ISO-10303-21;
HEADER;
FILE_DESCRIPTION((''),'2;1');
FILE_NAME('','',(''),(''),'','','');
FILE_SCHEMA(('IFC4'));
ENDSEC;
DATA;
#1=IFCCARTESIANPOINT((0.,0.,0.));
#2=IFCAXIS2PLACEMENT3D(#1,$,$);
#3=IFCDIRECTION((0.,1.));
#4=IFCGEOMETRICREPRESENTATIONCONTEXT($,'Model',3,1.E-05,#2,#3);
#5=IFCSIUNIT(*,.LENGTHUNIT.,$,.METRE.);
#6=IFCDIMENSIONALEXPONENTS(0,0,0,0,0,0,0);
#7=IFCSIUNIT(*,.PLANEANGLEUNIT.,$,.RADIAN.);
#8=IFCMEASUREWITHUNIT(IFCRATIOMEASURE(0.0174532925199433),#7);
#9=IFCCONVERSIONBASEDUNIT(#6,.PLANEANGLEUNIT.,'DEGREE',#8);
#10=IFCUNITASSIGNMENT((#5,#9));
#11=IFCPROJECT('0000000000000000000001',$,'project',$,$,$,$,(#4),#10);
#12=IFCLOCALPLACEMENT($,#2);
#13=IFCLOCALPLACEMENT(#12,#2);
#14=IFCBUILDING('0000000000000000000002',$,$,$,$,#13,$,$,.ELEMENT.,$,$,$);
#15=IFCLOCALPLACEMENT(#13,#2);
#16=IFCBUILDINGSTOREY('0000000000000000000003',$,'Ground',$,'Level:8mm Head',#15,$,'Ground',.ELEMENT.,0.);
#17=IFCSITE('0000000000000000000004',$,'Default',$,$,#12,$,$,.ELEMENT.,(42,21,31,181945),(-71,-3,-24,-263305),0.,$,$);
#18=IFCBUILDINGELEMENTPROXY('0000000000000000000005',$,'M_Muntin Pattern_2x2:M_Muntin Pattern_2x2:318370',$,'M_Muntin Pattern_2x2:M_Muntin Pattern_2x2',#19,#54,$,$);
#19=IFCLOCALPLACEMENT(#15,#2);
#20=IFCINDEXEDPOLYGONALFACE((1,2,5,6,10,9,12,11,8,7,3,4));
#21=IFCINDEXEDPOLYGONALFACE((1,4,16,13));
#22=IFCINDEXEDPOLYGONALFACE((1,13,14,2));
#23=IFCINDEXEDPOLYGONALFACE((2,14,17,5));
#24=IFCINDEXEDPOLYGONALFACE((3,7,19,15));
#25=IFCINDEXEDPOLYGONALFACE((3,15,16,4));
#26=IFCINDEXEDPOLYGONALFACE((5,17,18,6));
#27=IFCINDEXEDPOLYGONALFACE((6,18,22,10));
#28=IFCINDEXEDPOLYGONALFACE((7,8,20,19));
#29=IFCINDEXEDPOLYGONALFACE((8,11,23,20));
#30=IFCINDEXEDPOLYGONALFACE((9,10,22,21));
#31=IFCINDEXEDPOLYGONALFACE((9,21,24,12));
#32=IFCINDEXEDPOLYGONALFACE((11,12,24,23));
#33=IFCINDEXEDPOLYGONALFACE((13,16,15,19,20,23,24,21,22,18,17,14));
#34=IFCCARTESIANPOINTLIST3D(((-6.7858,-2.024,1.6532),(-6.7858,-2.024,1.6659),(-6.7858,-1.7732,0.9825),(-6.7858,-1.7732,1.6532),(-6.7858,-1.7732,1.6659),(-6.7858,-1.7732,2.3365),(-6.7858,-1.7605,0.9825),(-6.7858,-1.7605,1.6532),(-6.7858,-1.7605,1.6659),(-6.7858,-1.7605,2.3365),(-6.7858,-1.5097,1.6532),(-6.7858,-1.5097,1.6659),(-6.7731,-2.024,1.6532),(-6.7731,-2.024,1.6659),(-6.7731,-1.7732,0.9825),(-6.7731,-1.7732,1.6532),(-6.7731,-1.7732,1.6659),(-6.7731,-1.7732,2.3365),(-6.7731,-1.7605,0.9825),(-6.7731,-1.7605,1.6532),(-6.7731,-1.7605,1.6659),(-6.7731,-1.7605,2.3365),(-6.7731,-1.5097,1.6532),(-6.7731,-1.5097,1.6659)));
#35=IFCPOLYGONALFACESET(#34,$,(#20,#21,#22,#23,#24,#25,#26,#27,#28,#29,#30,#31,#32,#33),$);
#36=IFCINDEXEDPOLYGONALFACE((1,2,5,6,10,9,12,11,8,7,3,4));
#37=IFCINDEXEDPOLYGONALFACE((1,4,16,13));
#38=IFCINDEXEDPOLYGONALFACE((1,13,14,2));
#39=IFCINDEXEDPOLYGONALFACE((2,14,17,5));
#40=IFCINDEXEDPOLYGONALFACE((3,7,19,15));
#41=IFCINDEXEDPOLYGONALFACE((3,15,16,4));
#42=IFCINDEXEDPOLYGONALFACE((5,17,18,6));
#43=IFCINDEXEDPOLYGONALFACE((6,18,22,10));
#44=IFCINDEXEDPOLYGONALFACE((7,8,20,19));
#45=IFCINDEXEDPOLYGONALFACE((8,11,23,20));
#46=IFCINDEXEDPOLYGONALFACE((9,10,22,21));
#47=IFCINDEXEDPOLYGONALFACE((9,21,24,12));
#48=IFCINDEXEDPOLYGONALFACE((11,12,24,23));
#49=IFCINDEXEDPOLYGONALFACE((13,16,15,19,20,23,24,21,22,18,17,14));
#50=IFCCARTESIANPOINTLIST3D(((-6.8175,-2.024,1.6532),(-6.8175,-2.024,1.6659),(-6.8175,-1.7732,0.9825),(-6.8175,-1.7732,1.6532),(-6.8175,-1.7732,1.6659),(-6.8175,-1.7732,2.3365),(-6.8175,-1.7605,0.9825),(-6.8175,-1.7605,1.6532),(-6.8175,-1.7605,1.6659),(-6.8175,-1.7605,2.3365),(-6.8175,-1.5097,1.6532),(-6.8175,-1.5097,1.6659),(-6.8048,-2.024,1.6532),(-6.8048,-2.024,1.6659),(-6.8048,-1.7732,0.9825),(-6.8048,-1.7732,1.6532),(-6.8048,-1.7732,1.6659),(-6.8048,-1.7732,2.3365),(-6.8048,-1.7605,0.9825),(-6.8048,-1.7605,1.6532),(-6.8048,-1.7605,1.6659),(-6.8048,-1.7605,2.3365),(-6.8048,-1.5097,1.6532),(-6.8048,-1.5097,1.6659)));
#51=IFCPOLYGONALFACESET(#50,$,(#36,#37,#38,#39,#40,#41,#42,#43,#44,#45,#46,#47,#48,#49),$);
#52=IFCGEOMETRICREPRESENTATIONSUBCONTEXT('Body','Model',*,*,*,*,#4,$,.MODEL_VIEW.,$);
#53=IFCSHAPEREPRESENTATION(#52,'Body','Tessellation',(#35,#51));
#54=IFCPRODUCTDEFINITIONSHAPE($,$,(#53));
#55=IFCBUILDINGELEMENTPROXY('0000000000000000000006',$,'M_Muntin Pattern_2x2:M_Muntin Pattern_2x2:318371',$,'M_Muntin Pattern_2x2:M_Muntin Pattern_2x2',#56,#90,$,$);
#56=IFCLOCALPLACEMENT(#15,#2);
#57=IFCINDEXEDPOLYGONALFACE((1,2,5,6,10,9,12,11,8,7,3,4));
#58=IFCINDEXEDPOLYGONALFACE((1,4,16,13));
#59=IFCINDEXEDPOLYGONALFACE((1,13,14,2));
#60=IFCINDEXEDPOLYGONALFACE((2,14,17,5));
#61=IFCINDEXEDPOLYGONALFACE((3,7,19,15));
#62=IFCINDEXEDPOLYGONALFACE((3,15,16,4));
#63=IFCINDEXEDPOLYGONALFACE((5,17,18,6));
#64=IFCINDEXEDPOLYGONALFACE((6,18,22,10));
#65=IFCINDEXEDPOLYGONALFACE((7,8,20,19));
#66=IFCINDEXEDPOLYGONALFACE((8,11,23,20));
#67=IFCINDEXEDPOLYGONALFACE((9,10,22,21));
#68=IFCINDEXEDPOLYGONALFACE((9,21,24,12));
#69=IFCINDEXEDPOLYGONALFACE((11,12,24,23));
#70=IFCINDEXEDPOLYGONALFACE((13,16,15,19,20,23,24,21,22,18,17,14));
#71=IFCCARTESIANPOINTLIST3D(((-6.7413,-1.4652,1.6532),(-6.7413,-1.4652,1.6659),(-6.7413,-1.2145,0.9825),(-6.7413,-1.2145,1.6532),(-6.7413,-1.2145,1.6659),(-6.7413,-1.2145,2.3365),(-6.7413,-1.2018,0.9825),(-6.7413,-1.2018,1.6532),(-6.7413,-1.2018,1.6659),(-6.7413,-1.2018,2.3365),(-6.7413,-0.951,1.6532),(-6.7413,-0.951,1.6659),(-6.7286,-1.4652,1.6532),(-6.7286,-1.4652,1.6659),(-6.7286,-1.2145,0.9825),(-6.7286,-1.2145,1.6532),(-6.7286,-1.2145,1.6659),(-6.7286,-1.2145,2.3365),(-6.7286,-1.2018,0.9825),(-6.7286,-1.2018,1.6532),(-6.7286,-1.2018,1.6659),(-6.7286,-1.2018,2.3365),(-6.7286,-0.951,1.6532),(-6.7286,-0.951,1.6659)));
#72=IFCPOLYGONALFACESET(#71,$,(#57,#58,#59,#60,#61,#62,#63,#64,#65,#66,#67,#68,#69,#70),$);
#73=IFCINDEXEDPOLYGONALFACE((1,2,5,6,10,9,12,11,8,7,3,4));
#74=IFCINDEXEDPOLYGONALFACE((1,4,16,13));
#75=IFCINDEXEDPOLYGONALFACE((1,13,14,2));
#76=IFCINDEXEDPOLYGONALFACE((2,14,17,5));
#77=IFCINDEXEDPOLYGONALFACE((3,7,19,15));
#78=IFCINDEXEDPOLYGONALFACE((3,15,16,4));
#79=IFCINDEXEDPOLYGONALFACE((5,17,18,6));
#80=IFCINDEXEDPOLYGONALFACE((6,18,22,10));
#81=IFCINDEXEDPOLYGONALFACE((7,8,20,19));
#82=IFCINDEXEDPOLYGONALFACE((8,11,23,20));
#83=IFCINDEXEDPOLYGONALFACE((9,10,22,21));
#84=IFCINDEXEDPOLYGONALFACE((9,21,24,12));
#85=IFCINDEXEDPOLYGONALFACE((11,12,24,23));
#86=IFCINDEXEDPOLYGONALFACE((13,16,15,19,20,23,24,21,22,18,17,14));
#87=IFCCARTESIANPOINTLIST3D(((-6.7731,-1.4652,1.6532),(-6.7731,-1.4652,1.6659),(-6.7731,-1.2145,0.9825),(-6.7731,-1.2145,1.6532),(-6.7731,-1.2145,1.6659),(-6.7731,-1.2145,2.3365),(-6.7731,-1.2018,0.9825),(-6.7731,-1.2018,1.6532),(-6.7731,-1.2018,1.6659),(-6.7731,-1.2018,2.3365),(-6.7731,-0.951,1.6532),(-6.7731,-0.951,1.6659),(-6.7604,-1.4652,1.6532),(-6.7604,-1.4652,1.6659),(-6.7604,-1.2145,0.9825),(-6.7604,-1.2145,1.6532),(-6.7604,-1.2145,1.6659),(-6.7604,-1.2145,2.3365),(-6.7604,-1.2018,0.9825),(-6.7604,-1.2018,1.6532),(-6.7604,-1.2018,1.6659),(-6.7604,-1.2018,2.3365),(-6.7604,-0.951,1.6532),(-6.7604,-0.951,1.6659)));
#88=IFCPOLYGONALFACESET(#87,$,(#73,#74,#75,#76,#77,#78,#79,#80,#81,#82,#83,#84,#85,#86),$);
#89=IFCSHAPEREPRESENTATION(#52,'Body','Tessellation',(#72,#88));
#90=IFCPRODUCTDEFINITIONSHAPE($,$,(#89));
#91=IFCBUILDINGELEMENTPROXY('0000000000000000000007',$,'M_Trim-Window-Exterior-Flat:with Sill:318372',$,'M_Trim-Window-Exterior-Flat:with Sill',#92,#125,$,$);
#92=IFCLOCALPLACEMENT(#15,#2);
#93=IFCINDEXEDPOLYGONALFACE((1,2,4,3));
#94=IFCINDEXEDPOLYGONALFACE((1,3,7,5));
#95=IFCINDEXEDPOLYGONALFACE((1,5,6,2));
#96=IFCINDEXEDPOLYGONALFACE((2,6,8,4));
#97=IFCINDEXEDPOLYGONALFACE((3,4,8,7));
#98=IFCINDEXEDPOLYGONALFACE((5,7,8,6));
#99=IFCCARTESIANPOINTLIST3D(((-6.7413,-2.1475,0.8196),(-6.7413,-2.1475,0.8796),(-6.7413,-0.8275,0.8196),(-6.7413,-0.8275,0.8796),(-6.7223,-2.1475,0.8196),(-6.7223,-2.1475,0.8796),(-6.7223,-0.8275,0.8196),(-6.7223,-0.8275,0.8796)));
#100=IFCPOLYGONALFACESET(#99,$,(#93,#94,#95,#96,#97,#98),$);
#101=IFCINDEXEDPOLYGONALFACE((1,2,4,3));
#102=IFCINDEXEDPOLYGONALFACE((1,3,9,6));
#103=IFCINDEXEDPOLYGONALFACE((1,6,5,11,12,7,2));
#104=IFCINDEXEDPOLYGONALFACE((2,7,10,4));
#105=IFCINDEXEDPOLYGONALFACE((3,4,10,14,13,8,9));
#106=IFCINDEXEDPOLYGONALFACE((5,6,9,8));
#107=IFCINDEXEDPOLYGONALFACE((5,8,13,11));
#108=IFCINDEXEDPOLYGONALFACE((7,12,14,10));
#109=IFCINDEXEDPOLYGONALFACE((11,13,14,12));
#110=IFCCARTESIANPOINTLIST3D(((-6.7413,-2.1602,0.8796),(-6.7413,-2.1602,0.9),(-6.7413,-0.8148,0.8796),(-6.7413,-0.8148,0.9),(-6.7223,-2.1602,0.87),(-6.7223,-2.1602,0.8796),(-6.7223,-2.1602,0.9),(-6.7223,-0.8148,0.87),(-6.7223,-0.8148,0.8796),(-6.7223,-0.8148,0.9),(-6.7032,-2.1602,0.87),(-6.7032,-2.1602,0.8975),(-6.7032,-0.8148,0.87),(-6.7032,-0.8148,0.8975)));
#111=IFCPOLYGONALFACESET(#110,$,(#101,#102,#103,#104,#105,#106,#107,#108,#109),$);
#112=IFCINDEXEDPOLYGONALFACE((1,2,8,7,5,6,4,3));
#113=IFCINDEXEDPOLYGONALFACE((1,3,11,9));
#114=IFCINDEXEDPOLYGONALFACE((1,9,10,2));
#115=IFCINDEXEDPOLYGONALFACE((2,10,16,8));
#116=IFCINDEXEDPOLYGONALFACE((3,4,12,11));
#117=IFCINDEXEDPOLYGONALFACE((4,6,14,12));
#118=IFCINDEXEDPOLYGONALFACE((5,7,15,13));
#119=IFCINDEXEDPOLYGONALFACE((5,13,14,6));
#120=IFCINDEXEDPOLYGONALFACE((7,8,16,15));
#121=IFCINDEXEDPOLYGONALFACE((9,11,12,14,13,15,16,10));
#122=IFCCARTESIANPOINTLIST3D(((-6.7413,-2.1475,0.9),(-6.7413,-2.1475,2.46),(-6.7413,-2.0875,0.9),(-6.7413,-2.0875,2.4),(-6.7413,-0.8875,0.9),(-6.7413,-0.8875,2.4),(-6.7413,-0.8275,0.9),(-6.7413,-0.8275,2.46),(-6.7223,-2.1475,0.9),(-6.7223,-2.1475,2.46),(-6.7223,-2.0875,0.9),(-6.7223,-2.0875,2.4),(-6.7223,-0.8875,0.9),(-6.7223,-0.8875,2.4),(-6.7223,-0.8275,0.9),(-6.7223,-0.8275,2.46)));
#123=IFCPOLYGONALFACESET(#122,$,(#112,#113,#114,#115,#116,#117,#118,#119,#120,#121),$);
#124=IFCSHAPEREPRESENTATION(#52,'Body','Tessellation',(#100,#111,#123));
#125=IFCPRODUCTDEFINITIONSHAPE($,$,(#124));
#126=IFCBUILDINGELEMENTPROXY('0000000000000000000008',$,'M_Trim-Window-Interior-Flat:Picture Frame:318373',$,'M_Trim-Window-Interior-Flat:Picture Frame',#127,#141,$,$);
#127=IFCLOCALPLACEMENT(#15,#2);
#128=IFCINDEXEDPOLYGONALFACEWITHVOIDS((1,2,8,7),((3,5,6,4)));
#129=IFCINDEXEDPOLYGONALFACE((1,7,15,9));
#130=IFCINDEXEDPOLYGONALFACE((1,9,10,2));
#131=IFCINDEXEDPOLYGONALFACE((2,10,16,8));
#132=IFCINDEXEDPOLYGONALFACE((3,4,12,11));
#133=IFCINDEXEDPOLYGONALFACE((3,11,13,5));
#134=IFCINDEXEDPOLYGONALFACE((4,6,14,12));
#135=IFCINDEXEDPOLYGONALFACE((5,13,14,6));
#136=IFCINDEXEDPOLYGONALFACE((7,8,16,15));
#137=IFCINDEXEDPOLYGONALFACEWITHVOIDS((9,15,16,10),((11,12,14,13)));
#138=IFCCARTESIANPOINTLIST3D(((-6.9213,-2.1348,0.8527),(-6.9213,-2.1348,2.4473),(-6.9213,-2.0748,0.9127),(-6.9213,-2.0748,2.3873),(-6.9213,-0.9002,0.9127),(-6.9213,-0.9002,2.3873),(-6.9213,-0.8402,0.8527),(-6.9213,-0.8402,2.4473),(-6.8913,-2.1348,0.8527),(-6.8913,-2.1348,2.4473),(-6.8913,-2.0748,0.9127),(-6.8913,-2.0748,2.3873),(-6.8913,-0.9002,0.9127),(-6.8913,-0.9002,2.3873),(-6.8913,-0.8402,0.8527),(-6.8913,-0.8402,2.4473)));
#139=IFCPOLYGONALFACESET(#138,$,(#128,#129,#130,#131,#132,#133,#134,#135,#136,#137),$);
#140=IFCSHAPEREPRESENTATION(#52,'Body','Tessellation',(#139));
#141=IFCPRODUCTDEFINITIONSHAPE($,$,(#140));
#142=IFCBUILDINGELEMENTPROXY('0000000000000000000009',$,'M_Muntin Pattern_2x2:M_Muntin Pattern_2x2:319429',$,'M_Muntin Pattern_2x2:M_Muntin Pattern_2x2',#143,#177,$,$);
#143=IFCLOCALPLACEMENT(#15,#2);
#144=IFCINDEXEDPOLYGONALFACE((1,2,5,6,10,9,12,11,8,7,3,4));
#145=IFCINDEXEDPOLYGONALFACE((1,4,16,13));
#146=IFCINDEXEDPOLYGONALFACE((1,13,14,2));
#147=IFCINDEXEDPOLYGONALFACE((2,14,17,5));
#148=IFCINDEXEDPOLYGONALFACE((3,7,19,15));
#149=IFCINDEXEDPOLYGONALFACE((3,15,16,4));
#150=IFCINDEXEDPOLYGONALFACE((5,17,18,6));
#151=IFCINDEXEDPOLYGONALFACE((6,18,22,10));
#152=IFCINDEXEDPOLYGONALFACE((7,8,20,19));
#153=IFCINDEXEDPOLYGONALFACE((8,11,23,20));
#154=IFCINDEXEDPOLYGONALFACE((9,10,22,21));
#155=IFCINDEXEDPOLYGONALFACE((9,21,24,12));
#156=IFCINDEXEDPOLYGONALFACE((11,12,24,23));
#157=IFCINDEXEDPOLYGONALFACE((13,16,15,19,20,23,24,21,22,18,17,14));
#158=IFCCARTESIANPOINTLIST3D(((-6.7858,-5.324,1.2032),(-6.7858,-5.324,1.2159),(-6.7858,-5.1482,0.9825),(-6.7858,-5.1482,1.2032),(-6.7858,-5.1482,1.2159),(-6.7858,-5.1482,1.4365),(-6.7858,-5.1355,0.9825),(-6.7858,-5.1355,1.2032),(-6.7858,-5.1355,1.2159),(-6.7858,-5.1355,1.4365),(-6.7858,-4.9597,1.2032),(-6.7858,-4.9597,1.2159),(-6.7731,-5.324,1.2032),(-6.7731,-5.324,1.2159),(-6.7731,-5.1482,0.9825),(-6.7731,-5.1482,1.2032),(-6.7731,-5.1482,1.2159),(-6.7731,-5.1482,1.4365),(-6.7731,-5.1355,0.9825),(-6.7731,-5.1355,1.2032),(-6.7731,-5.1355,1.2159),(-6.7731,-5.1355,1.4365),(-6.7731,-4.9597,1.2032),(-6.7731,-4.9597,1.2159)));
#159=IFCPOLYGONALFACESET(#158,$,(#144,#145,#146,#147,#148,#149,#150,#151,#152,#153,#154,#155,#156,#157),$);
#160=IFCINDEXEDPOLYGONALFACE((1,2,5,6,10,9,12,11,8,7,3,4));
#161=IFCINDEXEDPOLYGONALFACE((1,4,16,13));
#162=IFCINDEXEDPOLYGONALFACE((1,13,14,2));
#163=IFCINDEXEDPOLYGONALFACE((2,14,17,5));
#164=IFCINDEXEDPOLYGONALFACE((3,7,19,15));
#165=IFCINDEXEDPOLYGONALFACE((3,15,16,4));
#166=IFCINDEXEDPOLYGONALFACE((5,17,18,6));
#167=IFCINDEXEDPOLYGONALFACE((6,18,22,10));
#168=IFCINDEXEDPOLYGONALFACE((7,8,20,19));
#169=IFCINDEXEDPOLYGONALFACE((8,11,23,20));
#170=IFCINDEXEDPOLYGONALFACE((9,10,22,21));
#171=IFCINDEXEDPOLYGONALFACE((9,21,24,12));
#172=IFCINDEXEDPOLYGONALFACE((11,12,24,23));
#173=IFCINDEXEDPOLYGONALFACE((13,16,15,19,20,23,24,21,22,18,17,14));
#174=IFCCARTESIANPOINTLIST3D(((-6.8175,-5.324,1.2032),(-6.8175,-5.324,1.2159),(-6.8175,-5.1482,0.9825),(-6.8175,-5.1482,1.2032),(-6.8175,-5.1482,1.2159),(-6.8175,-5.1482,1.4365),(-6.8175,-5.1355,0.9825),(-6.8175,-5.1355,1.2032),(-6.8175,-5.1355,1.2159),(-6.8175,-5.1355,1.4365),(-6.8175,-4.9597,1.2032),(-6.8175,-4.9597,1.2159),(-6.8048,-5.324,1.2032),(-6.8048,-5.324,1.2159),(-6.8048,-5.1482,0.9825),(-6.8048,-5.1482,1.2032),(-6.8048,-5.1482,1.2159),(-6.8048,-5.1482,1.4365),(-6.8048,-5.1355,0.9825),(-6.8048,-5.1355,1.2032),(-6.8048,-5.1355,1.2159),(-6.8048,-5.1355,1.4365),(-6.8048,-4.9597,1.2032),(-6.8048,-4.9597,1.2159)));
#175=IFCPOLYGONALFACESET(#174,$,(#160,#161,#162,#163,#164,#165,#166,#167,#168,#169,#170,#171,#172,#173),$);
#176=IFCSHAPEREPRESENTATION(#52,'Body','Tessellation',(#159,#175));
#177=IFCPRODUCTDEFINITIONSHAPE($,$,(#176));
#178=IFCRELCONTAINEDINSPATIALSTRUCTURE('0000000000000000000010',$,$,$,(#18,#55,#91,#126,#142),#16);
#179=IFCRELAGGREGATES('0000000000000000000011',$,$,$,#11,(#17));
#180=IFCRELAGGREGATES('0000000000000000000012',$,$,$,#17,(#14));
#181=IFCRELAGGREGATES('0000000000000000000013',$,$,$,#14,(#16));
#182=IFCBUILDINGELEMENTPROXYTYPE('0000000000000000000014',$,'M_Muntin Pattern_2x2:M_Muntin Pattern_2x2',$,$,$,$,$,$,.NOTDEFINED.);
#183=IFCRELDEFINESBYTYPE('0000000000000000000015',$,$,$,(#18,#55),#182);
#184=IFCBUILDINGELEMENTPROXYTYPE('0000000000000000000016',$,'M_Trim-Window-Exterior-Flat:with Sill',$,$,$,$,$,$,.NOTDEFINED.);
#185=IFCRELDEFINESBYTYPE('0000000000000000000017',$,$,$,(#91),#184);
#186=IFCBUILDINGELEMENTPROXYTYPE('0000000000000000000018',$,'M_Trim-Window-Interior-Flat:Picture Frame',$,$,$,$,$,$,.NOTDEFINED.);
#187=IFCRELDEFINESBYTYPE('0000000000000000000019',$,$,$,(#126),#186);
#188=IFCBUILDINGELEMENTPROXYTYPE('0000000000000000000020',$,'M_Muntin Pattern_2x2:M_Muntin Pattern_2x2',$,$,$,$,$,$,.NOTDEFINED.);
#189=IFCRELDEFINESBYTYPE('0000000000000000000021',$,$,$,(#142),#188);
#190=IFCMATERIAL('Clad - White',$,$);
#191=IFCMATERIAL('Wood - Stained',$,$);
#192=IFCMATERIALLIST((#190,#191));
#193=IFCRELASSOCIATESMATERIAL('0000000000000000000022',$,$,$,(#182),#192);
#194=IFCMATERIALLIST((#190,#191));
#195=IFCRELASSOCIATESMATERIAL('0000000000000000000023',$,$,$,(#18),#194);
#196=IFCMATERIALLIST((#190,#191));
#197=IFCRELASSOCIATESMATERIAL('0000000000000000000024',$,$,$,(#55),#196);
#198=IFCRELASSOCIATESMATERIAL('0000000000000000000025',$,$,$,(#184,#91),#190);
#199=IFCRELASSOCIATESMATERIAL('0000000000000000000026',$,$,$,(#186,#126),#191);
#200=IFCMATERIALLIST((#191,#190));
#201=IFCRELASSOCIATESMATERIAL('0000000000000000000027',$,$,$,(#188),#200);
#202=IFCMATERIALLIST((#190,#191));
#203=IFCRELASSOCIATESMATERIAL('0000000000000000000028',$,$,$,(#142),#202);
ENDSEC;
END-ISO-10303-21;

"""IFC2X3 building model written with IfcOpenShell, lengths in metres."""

from ifc_helpers import new_model, entity, si_unit, converted_unit, direction, frame, frame_2d, origin, place, context, subcontext, project, spatial, polyline, rectangle, outline, extrude, source, transform, mapped, material, material_list, type_object, type_shapes, element, save


model = new_model("IFC2X3")

# Units and contexts
model_context = context("Model", 3, precision=1e-05, world=origin(), true_north=direction((0.0, 1.0)))
body_context = subcontext(model_context, "Body", "Model", "MODEL_VIEW")
ifc_project = project(units=[si_unit("LENGTHUNIT", "METRE"), converted_unit("PLANEANGLEUNIT", "DEGREE", entity("IfcRatioMeasure", 0.0174532925199433), si_unit("PLANEANGLEUNIT", "RADIAN"), dimensions=[0, 0, 0, 0, 0, 0, 0])], contexts=[model_context])

# Site, building, storey
site_placement = place(None, origin())
site = spatial("IfcSite", under=ifc_project, at=site_placement, Name="Default", CompositionType="ELEMENT", RefLatitude=(42, 21, 31, 181945), RefLongitude=(-71, -3, -24, -263305), RefElevation=0.0)
building_placement = place(site_placement, origin())
building = spatial("IfcBuilding", under=site, at=building_placement, CompositionType="ELEMENT")
storey_placement = place(building_placement, origin())
storey = spatial("IfcBuildingStorey", under=building, at=storey_placement, Name="Ground", ObjectType="Level:8mm Head", LongName="Ground", CompositionType="ELEMENT", Elevation=0.0)

# Building element proxies
ifc_material_1 = material(Name="Clad - White")
ifc_material_2 = material(Name="Wood - Stained")
ifc_material_list_1 = material_list([ifc_material_1, ifc_material_2])
ifc_material_list_2 = material_list([ifc_material_1, ifc_material_2])
building_element_proxy_type_1 = type_object("IfcBuildingElementProxyType", Name="M_Muntin Pattern_2x2:M_Muntin Pattern_2x2", PredefinedType="NOTDEFINED", material=ifc_material_list_2)
shared_shape_1 = source(origin(), body_context, "Body", "SweptSolid", [
    extrude(outline(polyline([(0.0064, -0.0064), (0.677, -0.0064), (0.677, 0.0063), (0.0064, 0.0063), (0.0064, 0.2571), (-0.0063, 0.2571), (-0.0063, 0.0063), (-0.677, 0.0063), (-0.677, -0.0064), (-0.0063, -0.0064), (-0.0063, -0.2571), (0.0064, -0.2571), (0.0064, -0.0064)])), frame((0.0, 0.0095, 0.677), z_axis=(0.0, 1.0, 0.0), x_axis=(0.0, 0.0, 1.0)), (0.0, 0.0, 1.0), 0.0127),
    extrude(outline(polyline([(0.0064, -0.0064), (0.677, -0.0064), (0.677, 0.0063), (0.0064, 0.0063), (0.0064, 0.2571), (-0.0063, 0.2571), (-0.0063, 0.0063), (-0.677, 0.0063), (-0.677, -0.0064), (-0.0063, -0.0064), (-0.0063, -0.2571), (0.0064, -0.2571), (0.0064, -0.0064)])), frame((0.0, -0.0222, 0.677), z_axis=(0.0, 1.0, 0.0), x_axis=(0.0, 0.0, 1.0)), (0.0, 0.0, 1.0), 0.0127),
])
type_shapes(building_element_proxy_type_1, [shared_shape_1])
proxy_1_placement = place(storey_placement, frame((-6.7953, -1.7668, 0.9825), z_axis=(0.0, 0.0, 1.0), x_axis=(0.0, -1.0, 0.0)))
element("IfcBuildingElementProxy", 1, at=proxy_1_placement, inside=storey, type_object=building_element_proxy_type_1, material=ifc_material_list_1, Name="M_Muntin Pattern_2x2:M_Muntin Pattern_2x2:318370", ObjectType="M_Muntin Pattern_2x2:M_Muntin Pattern_2x2", context=body_context, shape_type="MappedRepresentation", body=[
    mapped(shared_shape_1, transform((0.0, 0.0, 0.0), scale=1.0)),
])
ifc_material_list_3 = material_list([ifc_material_1, ifc_material_2])
proxy_2_placement = place(storey_placement, frame((-6.7509, -1.2081, 0.9825), z_axis=(0.0, 0.0, 1.0), x_axis=(0.0, -1.0, 0.0)))
element("IfcBuildingElementProxy", 2, at=proxy_2_placement, inside=storey, type_object=building_element_proxy_type_1, material=ifc_material_list_3, Name="M_Muntin Pattern_2x2:M_Muntin Pattern_2x2:318371", ObjectType="M_Muntin Pattern_2x2:M_Muntin Pattern_2x2", context=body_context, shape_type="MappedRepresentation", body=[
    mapped(shared_shape_1, transform((0.0, 0.0, 0.0), scale=1.0)),
])
building_element_proxy_type_2 = type_object("IfcBuildingElementProxyType", Name="M_Trim-Window-Exterior-Flat:with Sill", PredefinedType="NOTDEFINED", material=ifc_material_1)
shared_shape_2 = source(origin(), body_context, "Body", "SweptSolid", [
    extrude(rectangle(XDim=1.32, YDim=0.06, at=frame_2d((0.0, 0.0), x_axis=(1.0, 0.0))), frame((0.0, -1.5504, 0.0), z_axis=(0.0, 0.0, 1.0), x_axis=(-1.0, 0.0, 0.0)), (0.0, 0.0, 1.0), 0.0191),
    extrude(outline(polyline([(-0.019, -0.0152), (0.0, -0.0152), (0.0, -0.0057), (0.019, -0.0057), (0.019, 0.0148), (0.0, 0.0148), (-0.019, 0.0123), (-0.019, -0.0152)])), frame((-0.6727, -1.5148, 0.019), z_axis=(1.0, 0.0, 0.0), x_axis=(0.0, 0.0, -1.0)), (0.0, 0.0, 1.0), 1.3454),
    extrude(outline(polyline([(-0.795, -0.66), (0.765, -0.66), (0.765, -0.6), (-0.735, -0.6), (-0.735, 0.6), (0.765, 0.6), (0.765, 0.66), (-0.795, 0.66), (-0.795, -0.66)])), frame((0.0, -0.735, 0.0), z_axis=(0.0, 0.0, 1.0), x_axis=(0.0, -1.0, 0.0)), (0.0, 0.0, 1.0), 0.0191),
])
type_shapes(building_element_proxy_type_2, [shared_shape_2])
proxy_3_placement = place(storey_placement, frame((-6.7413, -1.4875, 2.4), z_axis=(1.0, 0.0, 0.0), x_axis=(0.0, 1.0, 0.0)))
element("IfcBuildingElementProxy", 3, at=proxy_3_placement, inside=storey, type_object=building_element_proxy_type_2, material=ifc_material_1, Name="M_Trim-Window-Exterior-Flat:with Sill:318372", ObjectType="M_Trim-Window-Exterior-Flat:with Sill", context=body_context, shape_type="MappedRepresentation", body=[
    mapped(shared_shape_2, transform((0.0, 0.0, 0.0), scale=1.0)),
])
building_element_proxy_type_3 = type_object("IfcBuildingElementProxyType", Name="M_Trim-Window-Interior-Flat:Picture Frame", PredefinedType="NOTDEFINED", material=ifc_material_2)
shared_shape_3 = source(origin(), body_context, "Body", "SweptSolid", [
    extrude(outline(polyline([(-0.6473, -0.7973), (0.6473, -0.7973), (0.6473, 0.7973), (-0.6473, 0.7973), (-0.6473, -0.7973)]), holes=[polyline([(-0.5873, -0.7373), (-0.5873, 0.7373), (0.5873, 0.7373), (0.5873, -0.7373), (-0.5873, -0.7373)])]), frame((0.0, -0.75, 0.0), z_axis=(0.0, 0.0, 1.0), x_axis=(-1.0, 0.0, 0.0)), (0.0, 0.0, 1.0), 0.03),
])
type_shapes(building_element_proxy_type_3, [shared_shape_3])
proxy_4_placement = place(storey_placement, frame((-6.8913, -1.4875, 2.4), z_axis=(-1.0, 0.0, 0.0), x_axis=(0.0, -1.0, 0.0)))
element("IfcBuildingElementProxy", 4, at=proxy_4_placement, inside=storey, type_object=building_element_proxy_type_3, material=ifc_material_2, Name="M_Trim-Window-Interior-Flat:Picture Frame:318373", ObjectType="M_Trim-Window-Interior-Flat:Picture Frame", context=body_context, shape_type="MappedRepresentation", body=[
    mapped(shared_shape_3, transform((0.0, 0.0, 0.0), scale=1.0)),
])
ifc_material_list_4 = material_list([ifc_material_1, ifc_material_2])
ifc_material_list_5 = material_list([ifc_material_2, ifc_material_1])
building_element_proxy_type_4 = type_object("IfcBuildingElementProxyType", Name="M_Muntin Pattern_2x2:M_Muntin Pattern_2x2", PredefinedType="NOTDEFINED", material=ifc_material_list_5)
shared_shape_4 = source(origin(), body_context, "Body", "SweptSolid", [
    extrude(outline(polyline([(0.0064, -0.0064), (0.227, -0.0064), (0.227, 0.0063), (0.0064, 0.0063), (0.0064, 0.1821), (-0.0063, 0.1821), (-0.0063, 0.0063), (-0.227, 0.0063), (-0.227, -0.0064), (-0.0063, -0.0064), (-0.0063, -0.1821), (0.0064, -0.1821), (0.0064, -0.0064)])), frame((0.0, 0.0095, 0.227), z_axis=(0.0, 1.0, 0.0), x_axis=(0.0, 0.0, 1.0)), (0.0, 0.0, 1.0), 0.0127),
    extrude(outline(polyline([(0.0064, -0.0064), (0.227, -0.0064), (0.227, 0.0063), (0.0064, 0.0063), (0.0064, 0.1821), (-0.0063, 0.1821), (-0.0063, 0.0063), (-0.227, 0.0063), (-0.227, -0.0064), (-0.0063, -0.0064), (-0.0063, -0.1821), (0.0064, -0.1821), (0.0064, -0.0064)])), frame((0.0, -0.0222, 0.227), z_axis=(0.0, 1.0, 0.0), x_axis=(0.0, 0.0, 1.0)), (0.0, 0.0, 1.0), 0.0127),
])
type_shapes(building_element_proxy_type_4, [shared_shape_4])
proxy_5_placement = place(storey_placement, frame((-6.7953, -5.1418, 0.9825), z_axis=(0.0, 0.0, 1.0), x_axis=(0.0, -1.0, 0.0)))
element("IfcBuildingElementProxy", 5, at=proxy_5_placement, inside=storey, type_object=building_element_proxy_type_4, material=ifc_material_list_4, Name="M_Muntin Pattern_2x2:M_Muntin Pattern_2x2:319429", ObjectType="M_Muntin Pattern_2x2:M_Muntin Pattern_2x2", context=body_context, shape_type="MappedRepresentation", body=[
    mapped(shared_shape_4, transform((0.0, 0.0, 0.0), scale=1.0)),
])

save(model, "model.ifc")
